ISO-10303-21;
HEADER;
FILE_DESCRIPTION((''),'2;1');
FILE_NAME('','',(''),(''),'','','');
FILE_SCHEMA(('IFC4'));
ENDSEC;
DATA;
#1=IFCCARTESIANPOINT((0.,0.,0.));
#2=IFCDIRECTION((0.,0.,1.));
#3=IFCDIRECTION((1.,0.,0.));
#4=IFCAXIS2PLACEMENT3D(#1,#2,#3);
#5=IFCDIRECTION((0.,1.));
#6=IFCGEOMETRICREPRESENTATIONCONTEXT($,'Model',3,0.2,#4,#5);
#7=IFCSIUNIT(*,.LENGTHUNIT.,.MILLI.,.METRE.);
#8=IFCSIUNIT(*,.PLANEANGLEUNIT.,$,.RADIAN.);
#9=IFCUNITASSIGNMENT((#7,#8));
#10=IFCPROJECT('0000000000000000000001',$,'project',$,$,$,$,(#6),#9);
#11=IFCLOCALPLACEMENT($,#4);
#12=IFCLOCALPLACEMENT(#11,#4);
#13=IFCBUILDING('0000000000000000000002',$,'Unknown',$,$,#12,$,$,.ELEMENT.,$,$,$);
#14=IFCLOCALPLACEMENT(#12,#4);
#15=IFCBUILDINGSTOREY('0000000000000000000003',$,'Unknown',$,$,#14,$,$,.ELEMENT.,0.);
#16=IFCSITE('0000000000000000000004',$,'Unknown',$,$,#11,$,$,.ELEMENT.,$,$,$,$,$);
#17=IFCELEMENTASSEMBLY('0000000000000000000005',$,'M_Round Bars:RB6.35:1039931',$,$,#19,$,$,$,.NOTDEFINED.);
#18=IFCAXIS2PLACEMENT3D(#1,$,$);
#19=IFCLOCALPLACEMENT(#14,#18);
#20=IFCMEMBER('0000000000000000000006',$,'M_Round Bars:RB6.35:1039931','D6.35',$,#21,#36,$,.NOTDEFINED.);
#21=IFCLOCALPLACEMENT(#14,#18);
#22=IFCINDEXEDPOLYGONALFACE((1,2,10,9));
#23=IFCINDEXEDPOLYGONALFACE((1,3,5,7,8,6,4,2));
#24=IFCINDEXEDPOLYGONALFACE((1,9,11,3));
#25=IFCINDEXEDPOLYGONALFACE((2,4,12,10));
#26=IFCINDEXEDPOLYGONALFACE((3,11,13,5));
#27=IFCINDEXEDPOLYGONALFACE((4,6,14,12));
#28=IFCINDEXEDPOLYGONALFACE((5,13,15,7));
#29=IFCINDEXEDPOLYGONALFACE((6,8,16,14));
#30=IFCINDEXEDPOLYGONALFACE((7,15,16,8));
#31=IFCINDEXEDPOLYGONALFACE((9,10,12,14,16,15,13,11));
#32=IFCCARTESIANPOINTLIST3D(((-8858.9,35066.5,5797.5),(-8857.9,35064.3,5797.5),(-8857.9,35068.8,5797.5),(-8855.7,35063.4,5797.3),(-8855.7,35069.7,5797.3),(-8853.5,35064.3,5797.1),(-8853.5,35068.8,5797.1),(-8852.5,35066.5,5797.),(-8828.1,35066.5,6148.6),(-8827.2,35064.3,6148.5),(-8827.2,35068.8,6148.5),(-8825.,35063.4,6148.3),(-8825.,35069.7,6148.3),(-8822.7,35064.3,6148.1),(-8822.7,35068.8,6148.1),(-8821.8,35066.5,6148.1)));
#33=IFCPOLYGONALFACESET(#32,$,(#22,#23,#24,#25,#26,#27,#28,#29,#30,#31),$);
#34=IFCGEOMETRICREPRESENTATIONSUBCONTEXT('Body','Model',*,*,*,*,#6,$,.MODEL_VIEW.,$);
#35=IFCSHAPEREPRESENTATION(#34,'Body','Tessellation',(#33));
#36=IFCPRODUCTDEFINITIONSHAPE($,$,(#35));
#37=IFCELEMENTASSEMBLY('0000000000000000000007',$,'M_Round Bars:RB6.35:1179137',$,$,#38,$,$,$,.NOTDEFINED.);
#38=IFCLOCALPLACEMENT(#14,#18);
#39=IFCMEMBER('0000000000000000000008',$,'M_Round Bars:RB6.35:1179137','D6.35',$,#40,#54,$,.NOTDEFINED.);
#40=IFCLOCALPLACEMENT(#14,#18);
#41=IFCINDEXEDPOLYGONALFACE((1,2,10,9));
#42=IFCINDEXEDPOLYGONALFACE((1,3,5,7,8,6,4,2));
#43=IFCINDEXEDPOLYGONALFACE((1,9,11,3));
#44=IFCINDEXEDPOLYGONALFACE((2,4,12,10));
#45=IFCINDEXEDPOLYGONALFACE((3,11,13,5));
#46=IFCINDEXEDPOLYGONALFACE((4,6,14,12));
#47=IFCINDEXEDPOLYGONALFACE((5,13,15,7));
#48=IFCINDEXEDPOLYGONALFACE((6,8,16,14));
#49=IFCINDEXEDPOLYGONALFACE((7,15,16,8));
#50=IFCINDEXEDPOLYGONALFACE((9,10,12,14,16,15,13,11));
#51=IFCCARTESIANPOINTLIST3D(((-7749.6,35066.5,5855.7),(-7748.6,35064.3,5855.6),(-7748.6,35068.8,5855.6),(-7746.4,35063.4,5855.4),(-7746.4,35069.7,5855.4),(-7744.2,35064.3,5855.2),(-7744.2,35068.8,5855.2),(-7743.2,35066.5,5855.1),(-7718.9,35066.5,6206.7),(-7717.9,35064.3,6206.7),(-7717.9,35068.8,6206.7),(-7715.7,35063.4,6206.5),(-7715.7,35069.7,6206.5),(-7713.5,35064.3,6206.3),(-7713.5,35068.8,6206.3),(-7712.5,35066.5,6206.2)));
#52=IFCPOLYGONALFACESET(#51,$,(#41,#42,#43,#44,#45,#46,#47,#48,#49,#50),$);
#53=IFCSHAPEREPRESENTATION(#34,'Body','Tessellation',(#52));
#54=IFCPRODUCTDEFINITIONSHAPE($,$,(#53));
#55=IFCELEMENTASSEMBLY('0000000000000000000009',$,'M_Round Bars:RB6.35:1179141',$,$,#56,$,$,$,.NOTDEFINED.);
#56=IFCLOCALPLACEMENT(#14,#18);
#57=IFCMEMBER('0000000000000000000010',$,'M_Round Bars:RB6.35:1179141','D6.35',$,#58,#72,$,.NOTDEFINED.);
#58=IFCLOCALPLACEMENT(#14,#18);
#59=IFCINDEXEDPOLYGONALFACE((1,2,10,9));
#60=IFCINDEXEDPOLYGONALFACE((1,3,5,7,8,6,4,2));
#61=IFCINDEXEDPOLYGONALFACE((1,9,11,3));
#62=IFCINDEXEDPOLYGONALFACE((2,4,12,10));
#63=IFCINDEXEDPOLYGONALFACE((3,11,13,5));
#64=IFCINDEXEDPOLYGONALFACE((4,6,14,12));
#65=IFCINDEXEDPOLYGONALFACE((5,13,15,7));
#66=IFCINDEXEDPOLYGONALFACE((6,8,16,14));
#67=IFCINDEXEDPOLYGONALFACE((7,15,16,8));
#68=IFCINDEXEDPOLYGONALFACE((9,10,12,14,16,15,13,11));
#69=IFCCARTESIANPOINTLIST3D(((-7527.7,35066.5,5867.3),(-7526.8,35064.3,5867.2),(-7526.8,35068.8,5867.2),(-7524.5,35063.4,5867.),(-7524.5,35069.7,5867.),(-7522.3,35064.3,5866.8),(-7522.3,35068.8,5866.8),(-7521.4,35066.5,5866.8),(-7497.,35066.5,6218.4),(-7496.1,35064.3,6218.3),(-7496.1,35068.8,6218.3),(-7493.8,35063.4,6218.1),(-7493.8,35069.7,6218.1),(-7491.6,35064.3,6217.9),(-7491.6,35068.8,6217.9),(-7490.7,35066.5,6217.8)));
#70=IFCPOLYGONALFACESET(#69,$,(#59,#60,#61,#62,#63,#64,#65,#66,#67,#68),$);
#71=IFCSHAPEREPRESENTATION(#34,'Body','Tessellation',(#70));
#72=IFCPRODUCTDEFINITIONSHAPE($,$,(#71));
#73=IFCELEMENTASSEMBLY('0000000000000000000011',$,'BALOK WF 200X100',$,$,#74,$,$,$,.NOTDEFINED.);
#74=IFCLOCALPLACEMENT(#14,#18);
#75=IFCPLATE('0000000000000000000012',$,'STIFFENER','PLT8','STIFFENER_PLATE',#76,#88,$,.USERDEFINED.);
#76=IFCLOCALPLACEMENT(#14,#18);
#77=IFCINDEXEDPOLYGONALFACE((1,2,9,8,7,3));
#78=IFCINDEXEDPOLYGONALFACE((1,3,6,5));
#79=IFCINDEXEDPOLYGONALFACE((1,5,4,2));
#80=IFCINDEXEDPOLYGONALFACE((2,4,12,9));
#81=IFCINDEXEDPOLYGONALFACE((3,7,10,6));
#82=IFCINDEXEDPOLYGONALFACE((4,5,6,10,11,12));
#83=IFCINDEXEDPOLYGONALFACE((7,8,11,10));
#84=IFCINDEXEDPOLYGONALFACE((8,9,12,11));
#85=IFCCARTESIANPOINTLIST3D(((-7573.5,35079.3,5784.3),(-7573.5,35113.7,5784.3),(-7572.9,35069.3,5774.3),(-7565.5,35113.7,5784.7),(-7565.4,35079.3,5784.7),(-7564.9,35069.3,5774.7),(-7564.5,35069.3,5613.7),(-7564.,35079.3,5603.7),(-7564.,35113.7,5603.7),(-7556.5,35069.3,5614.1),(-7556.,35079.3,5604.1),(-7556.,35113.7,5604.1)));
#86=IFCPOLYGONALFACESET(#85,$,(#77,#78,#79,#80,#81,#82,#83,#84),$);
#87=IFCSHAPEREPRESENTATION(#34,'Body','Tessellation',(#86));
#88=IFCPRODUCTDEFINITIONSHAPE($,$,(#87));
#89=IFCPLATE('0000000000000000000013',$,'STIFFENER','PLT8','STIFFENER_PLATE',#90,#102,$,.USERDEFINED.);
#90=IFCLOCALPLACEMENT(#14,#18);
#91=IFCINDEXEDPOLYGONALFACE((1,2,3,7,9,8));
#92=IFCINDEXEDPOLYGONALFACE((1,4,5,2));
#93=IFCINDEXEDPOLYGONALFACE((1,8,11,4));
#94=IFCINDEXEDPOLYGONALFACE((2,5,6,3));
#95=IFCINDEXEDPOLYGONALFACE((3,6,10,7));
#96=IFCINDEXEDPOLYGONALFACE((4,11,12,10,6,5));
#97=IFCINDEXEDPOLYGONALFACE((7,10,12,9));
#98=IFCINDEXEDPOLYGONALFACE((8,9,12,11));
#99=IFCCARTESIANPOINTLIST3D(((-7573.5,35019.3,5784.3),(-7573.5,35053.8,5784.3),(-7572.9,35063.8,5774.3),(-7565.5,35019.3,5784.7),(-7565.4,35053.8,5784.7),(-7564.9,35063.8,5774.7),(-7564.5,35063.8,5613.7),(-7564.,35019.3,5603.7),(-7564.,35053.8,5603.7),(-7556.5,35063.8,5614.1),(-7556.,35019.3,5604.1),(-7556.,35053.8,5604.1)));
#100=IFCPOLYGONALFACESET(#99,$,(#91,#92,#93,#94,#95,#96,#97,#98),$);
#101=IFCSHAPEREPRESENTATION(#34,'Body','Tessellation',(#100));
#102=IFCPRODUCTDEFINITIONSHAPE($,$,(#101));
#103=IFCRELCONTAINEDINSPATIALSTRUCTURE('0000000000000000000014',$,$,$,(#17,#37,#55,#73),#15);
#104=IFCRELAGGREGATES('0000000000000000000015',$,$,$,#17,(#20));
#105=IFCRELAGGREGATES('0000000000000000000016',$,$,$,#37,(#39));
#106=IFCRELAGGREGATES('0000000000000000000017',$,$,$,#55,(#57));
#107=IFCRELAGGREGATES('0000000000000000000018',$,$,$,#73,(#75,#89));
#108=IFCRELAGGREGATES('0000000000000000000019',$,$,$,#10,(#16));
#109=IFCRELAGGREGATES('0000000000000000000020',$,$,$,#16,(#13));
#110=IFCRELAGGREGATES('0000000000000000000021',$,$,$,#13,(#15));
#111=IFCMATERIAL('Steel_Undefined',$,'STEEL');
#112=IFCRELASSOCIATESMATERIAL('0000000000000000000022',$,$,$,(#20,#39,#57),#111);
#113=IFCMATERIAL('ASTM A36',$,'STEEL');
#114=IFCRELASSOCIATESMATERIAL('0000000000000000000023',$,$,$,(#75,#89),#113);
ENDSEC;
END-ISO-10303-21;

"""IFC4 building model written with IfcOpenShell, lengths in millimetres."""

from ifc_helpers import new_model, si_unit, direction, frame, origin_with_axes, place, context, subcontext, project, spatial, line, indexed_curve, outline, extrude, material, element, aggregate, save


model = new_model("IFC4")

# Units and contexts
model_context = context("Model", 3, precision=0.2, world=origin_with_axes(), true_north=direction((0.0, 1.0)))
body_context = subcontext(model_context, "Body", "Model", "MODEL_VIEW")
ifc_project = project(units=[si_unit("LENGTHUNIT", "METRE", prefix="MILLI"), si_unit("PLANEANGLEUNIT", "RADIAN")], contexts=[model_context])

# Site, building, storey
site_placement = place(None, origin_with_axes())
site = spatial("IfcSite", under=ifc_project, at=site_placement, Name="Unknown", CompositionType="ELEMENT")
building_placement = place(site_placement, origin_with_axes())
building = spatial("IfcBuilding", under=site, at=building_placement, Name="Unknown", CompositionType="ELEMENT")
storey_placement = place(building_placement, origin_with_axes())
storey = spatial("IfcBuildingStorey", under=building, at=storey_placement, Name="Unknown", CompositionType="ELEMENT", Elevation=0.0)

# Element assemblies, members
ifc_material_1 = material(Name="Steel_Undefined", Category="STEEL")
assembly_1_placement = place(storey_placement, frame((-8825.0, 35066.5, 6148.3), z_axis=(0.0, -1.0, 0.0), x_axis=(-0.087153, 0.0, -0.996195)))
assembly_1 = element("IfcElementAssembly", 1, at=assembly_1_placement, inside=storey, Name="M_Round Bars:RB6.35:1039931", PredefinedType="NOTDEFINED")
member_1_placement = place(assembly_1_placement, origin_with_axes())
member_1 = element("IfcMember", 2, at=member_1_placement, material=ifc_material_1, Name="M_Round Bars:RB6.35:1039931", Description="D6.35", PredefinedType="NOTDEFINED", context=body_context, shape_type="SolidModel", body=[
    extrude(outline(indexed_curve([(3.2, 0.0), (2.2, 2.2), (0.0, 3.2), (-2.2, 2.2), (-3.2, 0.0), (-2.2, -2.2), (0.0, -3.2), (2.2, -2.2)], segments=[line(1, 2, 3, 4, 5, 6, 7, 8, 1)])), frame((0.0, 0.0, 0.0), z_axis=(-1.0, 0.0, 0.0), x_axis=(0.0, 0.0, 1.0)), (0.0, 0.0, -1.0), 352.4),
])
aggregate(assembly_1, [member_1])
assembly_2_placement = place(storey_placement, frame((-7715.7, 35066.5, 6206.5), z_axis=(0.0, -1.0, 0.0), x_axis=(-0.087153, 0.0, -0.996195)))
assembly_2 = element("IfcElementAssembly", 3, at=assembly_2_placement, inside=storey, Name="M_Round Bars:RB6.35:1179137", PredefinedType="NOTDEFINED")
member_2_placement = place(assembly_2_placement, origin_with_axes())
member_2 = element("IfcMember", 4, at=member_2_placement, material=ifc_material_1, Name="M_Round Bars:RB6.35:1179137", Description="D6.35", PredefinedType="NOTDEFINED", context=body_context, shape_type="SolidModel", body=[
    extrude(outline(indexed_curve([(3.2, 0.0), (2.2, 2.2), (0.0, 3.2), (-2.2, 2.2), (-3.2, 0.0), (-2.2, -2.2), (0.0, -3.2), (2.2, -2.2)], segments=[line(1, 2, 3, 4, 5, 6, 7, 8, 1)])), frame((0.0, 0.0, 0.0), z_axis=(-1.0, 0.0, 0.0), x_axis=(0.0, 0.0, 1.0)), (0.0, 0.0, -1.0), 352.4),
])
aggregate(assembly_2, [member_2])
assembly_3_placement = place(storey_placement, frame((-7493.8, 35066.5, 6218.1), z_axis=(0.0, -1.0, 0.0), x_axis=(-0.087153, 0.0, -0.996195)))
assembly_3 = element("IfcElementAssembly", 5, at=assembly_3_placement, inside=storey, Name="M_Round Bars:RB6.35:1179141", PredefinedType="NOTDEFINED")
member_3_placement = place(assembly_3_placement, origin_with_axes())
member_3 = element("IfcMember", 6, at=member_3_placement, material=ifc_material_1, Name="M_Round Bars:RB6.35:1179141", Description="D6.35", PredefinedType="NOTDEFINED", context=body_context, shape_type="SolidModel", body=[
    extrude(outline(indexed_curve([(3.2, 0.0), (2.2, 2.2), (0.0, 3.2), (-2.2, 2.2), (-3.2, 0.0), (-2.2, -2.2), (0.0, -3.2), (2.2, -2.2)], segments=[line(1, 2, 3, 4, 5, 6, 7, 8, 1)])), frame((0.0, 0.0, 0.0), z_axis=(-1.0, 0.0, 0.0), x_axis=(0.0, 0.0, 1.0)), (0.0, 0.0, -1.0), 352.4),
])
aggregate(assembly_3, [member_3])

# Shared definitions
ifc_material_2 = material(Name="ASTM A36", Category="STEEL")

# Element assembly, plates, voiding features
assembly_4_placement = place(storey_placement, frame((-12592.0, 35066.5, 5430.7), z_axis=(0.0, -1.0, 0.0), x_axis=(0.99863, 0.0, 0.052336)))
assembly_4 = element("IfcElementAssembly", 7, at=assembly_4_placement, inside=storey, Name="BALOK WF 200X100", PredefinedType="NOTDEFINED")
plate_1_placement = place(assembly_4_placement, frame((5034.2, -90.4, -47.2), z_axis=(-1.0, 0.0, 0.0), x_axis=(0.0, 0.0, 1.0)))
plate_1 = element("IfcPlate", 8, at=plate_1_placement, material=ifc_material_2, Name="STIFFENER", Description="PLT8", ObjectType="STIFFENER_PLATE", PredefinedType="USERDEFINED", context=body_context, shape_type="SolidModel", body=[
    extrude(outline(indexed_curve([(0.0, 0.0), (44.5, 0.0), (44.5, 180.8), (0.0, 180.8)], segments=[line(1, 2, 3, 4, 1)])), frame((0.0, 0.0, 4.0), z_axis=(0.0, 0.0, 1.0), x_axis=(1.0, 0.0, 0.0)), (0.0, 0.0, -1.0), 8.0),
])
voiding_feature_1_placement = place(plate_1_placement, frame((34.5, 180.8, 0.0), z_axis=(0.0, 0.0, 1.0), x_axis=(0.707107, -0.707107, 0.0)))
element("IfcVoidingFeature", 9, at=voiding_feature_1_placement, cuts=plate_1, Name="SLAB", PredefinedType="HOLE", context=body_context, shape_type="SolidModel", body=[
    extrude(outline(indexed_curve([(0.0, 0.0), (14.1, 0.0), (7.1, 7.1)], segments=[line(1, 2, 3, 1)])), frame((0.0, 0.0, 4.0), z_axis=(0.0, 0.0, 1.0), x_axis=(1.0, 0.0, 0.0)), (0.0, 0.0, -1.0), 8.0),
])
voiding_feature_2_placement = place(plate_1_placement, frame((34.5, 0.0, 0.0), z_axis=(0.0, 0.0, 1.0), x_axis=(1.0, 0.0, 0.0)))
element("IfcVoidingFeature", 10, at=voiding_feature_2_placement, cuts=plate_1, Name="SLAB", PredefinedType="HOLE", context=body_context, shape_type="SolidModel", body=[
    extrude(outline(indexed_curve([(0.0, 0.0), (10.0, 0.0), (10.0, 10.0)], segments=[line(1, 2, 3, 1)])), frame((0.0, 0.0, 4.0), z_axis=(0.0, 0.0, 1.0), x_axis=(1.0, 0.0, 0.0)), (0.0, 0.0, -1.0), 8.0),
])
plate_2_placement = place(assembly_4_placement, frame((5034.2, -90.4, 2.8), z_axis=(-1.0, 0.0, 0.0), x_axis=(0.0, 0.0, 1.0)))
plate_2 = element("IfcPlate", 11, at=plate_2_placement, material=ifc_material_2, Name="STIFFENER", Description="PLT8", ObjectType="STIFFENER_PLATE", PredefinedType="USERDEFINED", context=body_context, shape_type="SolidModel", body=[
    extrude(outline(indexed_curve([(0.0, 0.0), (44.5, 0.0), (44.5, 180.8), (0.0, 180.8)], segments=[line(1, 2, 3, 4, 1)])), frame((0.0, 0.0, 4.0), z_axis=(0.0, 0.0, 1.0), x_axis=(1.0, 0.0, 0.0)), (0.0, 0.0, -1.0), 8.0),
])
voiding_feature_3_placement = place(plate_2_placement, frame((0.0, 170.8, 0.0), z_axis=(0.0, 0.0, 1.0), x_axis=(0.707107, 0.707107, 0.0)))
element("IfcVoidingFeature", 12, at=voiding_feature_3_placement, cuts=plate_2, Name="SLAB", PredefinedType="HOLE", context=body_context, shape_type="SolidModel", body=[
    extrude(outline(indexed_curve([(0.0, 0.0), (14.1, 0.0), (7.1, 7.1)], segments=[line(1, 2, 3, 1)])), frame((0.0, 0.0, 4.0), z_axis=(0.0, 0.0, 1.0), x_axis=(1.0, 0.0, 0.0)), (0.0, 0.0, -1.0), 8.0),
])
voiding_feature_4_placement = place(plate_2_placement, frame((10.0, 0.0, 0.0), z_axis=(0.0, 0.0, 1.0), x_axis=(-0.707107, 0.707107, 0.0)))
element("IfcVoidingFeature", 13, at=voiding_feature_4_placement, cuts=plate_2, Name="SLAB", PredefinedType="HOLE", context=body_context, shape_type="SolidModel", body=[
    extrude(outline(indexed_curve([(0.0, 0.0), (14.1, 0.0), (7.1, 7.1)], segments=[line(1, 2, 3, 1)])), frame((0.0, 0.0, 4.0), z_axis=(0.0, 0.0, 1.0), x_axis=(1.0, 0.0, 0.0)), (0.0, 0.0, -1.0), 8.0),
])
aggregate(assembly_4, [plate_1, plate_2])

save(model, "model.ifc")
